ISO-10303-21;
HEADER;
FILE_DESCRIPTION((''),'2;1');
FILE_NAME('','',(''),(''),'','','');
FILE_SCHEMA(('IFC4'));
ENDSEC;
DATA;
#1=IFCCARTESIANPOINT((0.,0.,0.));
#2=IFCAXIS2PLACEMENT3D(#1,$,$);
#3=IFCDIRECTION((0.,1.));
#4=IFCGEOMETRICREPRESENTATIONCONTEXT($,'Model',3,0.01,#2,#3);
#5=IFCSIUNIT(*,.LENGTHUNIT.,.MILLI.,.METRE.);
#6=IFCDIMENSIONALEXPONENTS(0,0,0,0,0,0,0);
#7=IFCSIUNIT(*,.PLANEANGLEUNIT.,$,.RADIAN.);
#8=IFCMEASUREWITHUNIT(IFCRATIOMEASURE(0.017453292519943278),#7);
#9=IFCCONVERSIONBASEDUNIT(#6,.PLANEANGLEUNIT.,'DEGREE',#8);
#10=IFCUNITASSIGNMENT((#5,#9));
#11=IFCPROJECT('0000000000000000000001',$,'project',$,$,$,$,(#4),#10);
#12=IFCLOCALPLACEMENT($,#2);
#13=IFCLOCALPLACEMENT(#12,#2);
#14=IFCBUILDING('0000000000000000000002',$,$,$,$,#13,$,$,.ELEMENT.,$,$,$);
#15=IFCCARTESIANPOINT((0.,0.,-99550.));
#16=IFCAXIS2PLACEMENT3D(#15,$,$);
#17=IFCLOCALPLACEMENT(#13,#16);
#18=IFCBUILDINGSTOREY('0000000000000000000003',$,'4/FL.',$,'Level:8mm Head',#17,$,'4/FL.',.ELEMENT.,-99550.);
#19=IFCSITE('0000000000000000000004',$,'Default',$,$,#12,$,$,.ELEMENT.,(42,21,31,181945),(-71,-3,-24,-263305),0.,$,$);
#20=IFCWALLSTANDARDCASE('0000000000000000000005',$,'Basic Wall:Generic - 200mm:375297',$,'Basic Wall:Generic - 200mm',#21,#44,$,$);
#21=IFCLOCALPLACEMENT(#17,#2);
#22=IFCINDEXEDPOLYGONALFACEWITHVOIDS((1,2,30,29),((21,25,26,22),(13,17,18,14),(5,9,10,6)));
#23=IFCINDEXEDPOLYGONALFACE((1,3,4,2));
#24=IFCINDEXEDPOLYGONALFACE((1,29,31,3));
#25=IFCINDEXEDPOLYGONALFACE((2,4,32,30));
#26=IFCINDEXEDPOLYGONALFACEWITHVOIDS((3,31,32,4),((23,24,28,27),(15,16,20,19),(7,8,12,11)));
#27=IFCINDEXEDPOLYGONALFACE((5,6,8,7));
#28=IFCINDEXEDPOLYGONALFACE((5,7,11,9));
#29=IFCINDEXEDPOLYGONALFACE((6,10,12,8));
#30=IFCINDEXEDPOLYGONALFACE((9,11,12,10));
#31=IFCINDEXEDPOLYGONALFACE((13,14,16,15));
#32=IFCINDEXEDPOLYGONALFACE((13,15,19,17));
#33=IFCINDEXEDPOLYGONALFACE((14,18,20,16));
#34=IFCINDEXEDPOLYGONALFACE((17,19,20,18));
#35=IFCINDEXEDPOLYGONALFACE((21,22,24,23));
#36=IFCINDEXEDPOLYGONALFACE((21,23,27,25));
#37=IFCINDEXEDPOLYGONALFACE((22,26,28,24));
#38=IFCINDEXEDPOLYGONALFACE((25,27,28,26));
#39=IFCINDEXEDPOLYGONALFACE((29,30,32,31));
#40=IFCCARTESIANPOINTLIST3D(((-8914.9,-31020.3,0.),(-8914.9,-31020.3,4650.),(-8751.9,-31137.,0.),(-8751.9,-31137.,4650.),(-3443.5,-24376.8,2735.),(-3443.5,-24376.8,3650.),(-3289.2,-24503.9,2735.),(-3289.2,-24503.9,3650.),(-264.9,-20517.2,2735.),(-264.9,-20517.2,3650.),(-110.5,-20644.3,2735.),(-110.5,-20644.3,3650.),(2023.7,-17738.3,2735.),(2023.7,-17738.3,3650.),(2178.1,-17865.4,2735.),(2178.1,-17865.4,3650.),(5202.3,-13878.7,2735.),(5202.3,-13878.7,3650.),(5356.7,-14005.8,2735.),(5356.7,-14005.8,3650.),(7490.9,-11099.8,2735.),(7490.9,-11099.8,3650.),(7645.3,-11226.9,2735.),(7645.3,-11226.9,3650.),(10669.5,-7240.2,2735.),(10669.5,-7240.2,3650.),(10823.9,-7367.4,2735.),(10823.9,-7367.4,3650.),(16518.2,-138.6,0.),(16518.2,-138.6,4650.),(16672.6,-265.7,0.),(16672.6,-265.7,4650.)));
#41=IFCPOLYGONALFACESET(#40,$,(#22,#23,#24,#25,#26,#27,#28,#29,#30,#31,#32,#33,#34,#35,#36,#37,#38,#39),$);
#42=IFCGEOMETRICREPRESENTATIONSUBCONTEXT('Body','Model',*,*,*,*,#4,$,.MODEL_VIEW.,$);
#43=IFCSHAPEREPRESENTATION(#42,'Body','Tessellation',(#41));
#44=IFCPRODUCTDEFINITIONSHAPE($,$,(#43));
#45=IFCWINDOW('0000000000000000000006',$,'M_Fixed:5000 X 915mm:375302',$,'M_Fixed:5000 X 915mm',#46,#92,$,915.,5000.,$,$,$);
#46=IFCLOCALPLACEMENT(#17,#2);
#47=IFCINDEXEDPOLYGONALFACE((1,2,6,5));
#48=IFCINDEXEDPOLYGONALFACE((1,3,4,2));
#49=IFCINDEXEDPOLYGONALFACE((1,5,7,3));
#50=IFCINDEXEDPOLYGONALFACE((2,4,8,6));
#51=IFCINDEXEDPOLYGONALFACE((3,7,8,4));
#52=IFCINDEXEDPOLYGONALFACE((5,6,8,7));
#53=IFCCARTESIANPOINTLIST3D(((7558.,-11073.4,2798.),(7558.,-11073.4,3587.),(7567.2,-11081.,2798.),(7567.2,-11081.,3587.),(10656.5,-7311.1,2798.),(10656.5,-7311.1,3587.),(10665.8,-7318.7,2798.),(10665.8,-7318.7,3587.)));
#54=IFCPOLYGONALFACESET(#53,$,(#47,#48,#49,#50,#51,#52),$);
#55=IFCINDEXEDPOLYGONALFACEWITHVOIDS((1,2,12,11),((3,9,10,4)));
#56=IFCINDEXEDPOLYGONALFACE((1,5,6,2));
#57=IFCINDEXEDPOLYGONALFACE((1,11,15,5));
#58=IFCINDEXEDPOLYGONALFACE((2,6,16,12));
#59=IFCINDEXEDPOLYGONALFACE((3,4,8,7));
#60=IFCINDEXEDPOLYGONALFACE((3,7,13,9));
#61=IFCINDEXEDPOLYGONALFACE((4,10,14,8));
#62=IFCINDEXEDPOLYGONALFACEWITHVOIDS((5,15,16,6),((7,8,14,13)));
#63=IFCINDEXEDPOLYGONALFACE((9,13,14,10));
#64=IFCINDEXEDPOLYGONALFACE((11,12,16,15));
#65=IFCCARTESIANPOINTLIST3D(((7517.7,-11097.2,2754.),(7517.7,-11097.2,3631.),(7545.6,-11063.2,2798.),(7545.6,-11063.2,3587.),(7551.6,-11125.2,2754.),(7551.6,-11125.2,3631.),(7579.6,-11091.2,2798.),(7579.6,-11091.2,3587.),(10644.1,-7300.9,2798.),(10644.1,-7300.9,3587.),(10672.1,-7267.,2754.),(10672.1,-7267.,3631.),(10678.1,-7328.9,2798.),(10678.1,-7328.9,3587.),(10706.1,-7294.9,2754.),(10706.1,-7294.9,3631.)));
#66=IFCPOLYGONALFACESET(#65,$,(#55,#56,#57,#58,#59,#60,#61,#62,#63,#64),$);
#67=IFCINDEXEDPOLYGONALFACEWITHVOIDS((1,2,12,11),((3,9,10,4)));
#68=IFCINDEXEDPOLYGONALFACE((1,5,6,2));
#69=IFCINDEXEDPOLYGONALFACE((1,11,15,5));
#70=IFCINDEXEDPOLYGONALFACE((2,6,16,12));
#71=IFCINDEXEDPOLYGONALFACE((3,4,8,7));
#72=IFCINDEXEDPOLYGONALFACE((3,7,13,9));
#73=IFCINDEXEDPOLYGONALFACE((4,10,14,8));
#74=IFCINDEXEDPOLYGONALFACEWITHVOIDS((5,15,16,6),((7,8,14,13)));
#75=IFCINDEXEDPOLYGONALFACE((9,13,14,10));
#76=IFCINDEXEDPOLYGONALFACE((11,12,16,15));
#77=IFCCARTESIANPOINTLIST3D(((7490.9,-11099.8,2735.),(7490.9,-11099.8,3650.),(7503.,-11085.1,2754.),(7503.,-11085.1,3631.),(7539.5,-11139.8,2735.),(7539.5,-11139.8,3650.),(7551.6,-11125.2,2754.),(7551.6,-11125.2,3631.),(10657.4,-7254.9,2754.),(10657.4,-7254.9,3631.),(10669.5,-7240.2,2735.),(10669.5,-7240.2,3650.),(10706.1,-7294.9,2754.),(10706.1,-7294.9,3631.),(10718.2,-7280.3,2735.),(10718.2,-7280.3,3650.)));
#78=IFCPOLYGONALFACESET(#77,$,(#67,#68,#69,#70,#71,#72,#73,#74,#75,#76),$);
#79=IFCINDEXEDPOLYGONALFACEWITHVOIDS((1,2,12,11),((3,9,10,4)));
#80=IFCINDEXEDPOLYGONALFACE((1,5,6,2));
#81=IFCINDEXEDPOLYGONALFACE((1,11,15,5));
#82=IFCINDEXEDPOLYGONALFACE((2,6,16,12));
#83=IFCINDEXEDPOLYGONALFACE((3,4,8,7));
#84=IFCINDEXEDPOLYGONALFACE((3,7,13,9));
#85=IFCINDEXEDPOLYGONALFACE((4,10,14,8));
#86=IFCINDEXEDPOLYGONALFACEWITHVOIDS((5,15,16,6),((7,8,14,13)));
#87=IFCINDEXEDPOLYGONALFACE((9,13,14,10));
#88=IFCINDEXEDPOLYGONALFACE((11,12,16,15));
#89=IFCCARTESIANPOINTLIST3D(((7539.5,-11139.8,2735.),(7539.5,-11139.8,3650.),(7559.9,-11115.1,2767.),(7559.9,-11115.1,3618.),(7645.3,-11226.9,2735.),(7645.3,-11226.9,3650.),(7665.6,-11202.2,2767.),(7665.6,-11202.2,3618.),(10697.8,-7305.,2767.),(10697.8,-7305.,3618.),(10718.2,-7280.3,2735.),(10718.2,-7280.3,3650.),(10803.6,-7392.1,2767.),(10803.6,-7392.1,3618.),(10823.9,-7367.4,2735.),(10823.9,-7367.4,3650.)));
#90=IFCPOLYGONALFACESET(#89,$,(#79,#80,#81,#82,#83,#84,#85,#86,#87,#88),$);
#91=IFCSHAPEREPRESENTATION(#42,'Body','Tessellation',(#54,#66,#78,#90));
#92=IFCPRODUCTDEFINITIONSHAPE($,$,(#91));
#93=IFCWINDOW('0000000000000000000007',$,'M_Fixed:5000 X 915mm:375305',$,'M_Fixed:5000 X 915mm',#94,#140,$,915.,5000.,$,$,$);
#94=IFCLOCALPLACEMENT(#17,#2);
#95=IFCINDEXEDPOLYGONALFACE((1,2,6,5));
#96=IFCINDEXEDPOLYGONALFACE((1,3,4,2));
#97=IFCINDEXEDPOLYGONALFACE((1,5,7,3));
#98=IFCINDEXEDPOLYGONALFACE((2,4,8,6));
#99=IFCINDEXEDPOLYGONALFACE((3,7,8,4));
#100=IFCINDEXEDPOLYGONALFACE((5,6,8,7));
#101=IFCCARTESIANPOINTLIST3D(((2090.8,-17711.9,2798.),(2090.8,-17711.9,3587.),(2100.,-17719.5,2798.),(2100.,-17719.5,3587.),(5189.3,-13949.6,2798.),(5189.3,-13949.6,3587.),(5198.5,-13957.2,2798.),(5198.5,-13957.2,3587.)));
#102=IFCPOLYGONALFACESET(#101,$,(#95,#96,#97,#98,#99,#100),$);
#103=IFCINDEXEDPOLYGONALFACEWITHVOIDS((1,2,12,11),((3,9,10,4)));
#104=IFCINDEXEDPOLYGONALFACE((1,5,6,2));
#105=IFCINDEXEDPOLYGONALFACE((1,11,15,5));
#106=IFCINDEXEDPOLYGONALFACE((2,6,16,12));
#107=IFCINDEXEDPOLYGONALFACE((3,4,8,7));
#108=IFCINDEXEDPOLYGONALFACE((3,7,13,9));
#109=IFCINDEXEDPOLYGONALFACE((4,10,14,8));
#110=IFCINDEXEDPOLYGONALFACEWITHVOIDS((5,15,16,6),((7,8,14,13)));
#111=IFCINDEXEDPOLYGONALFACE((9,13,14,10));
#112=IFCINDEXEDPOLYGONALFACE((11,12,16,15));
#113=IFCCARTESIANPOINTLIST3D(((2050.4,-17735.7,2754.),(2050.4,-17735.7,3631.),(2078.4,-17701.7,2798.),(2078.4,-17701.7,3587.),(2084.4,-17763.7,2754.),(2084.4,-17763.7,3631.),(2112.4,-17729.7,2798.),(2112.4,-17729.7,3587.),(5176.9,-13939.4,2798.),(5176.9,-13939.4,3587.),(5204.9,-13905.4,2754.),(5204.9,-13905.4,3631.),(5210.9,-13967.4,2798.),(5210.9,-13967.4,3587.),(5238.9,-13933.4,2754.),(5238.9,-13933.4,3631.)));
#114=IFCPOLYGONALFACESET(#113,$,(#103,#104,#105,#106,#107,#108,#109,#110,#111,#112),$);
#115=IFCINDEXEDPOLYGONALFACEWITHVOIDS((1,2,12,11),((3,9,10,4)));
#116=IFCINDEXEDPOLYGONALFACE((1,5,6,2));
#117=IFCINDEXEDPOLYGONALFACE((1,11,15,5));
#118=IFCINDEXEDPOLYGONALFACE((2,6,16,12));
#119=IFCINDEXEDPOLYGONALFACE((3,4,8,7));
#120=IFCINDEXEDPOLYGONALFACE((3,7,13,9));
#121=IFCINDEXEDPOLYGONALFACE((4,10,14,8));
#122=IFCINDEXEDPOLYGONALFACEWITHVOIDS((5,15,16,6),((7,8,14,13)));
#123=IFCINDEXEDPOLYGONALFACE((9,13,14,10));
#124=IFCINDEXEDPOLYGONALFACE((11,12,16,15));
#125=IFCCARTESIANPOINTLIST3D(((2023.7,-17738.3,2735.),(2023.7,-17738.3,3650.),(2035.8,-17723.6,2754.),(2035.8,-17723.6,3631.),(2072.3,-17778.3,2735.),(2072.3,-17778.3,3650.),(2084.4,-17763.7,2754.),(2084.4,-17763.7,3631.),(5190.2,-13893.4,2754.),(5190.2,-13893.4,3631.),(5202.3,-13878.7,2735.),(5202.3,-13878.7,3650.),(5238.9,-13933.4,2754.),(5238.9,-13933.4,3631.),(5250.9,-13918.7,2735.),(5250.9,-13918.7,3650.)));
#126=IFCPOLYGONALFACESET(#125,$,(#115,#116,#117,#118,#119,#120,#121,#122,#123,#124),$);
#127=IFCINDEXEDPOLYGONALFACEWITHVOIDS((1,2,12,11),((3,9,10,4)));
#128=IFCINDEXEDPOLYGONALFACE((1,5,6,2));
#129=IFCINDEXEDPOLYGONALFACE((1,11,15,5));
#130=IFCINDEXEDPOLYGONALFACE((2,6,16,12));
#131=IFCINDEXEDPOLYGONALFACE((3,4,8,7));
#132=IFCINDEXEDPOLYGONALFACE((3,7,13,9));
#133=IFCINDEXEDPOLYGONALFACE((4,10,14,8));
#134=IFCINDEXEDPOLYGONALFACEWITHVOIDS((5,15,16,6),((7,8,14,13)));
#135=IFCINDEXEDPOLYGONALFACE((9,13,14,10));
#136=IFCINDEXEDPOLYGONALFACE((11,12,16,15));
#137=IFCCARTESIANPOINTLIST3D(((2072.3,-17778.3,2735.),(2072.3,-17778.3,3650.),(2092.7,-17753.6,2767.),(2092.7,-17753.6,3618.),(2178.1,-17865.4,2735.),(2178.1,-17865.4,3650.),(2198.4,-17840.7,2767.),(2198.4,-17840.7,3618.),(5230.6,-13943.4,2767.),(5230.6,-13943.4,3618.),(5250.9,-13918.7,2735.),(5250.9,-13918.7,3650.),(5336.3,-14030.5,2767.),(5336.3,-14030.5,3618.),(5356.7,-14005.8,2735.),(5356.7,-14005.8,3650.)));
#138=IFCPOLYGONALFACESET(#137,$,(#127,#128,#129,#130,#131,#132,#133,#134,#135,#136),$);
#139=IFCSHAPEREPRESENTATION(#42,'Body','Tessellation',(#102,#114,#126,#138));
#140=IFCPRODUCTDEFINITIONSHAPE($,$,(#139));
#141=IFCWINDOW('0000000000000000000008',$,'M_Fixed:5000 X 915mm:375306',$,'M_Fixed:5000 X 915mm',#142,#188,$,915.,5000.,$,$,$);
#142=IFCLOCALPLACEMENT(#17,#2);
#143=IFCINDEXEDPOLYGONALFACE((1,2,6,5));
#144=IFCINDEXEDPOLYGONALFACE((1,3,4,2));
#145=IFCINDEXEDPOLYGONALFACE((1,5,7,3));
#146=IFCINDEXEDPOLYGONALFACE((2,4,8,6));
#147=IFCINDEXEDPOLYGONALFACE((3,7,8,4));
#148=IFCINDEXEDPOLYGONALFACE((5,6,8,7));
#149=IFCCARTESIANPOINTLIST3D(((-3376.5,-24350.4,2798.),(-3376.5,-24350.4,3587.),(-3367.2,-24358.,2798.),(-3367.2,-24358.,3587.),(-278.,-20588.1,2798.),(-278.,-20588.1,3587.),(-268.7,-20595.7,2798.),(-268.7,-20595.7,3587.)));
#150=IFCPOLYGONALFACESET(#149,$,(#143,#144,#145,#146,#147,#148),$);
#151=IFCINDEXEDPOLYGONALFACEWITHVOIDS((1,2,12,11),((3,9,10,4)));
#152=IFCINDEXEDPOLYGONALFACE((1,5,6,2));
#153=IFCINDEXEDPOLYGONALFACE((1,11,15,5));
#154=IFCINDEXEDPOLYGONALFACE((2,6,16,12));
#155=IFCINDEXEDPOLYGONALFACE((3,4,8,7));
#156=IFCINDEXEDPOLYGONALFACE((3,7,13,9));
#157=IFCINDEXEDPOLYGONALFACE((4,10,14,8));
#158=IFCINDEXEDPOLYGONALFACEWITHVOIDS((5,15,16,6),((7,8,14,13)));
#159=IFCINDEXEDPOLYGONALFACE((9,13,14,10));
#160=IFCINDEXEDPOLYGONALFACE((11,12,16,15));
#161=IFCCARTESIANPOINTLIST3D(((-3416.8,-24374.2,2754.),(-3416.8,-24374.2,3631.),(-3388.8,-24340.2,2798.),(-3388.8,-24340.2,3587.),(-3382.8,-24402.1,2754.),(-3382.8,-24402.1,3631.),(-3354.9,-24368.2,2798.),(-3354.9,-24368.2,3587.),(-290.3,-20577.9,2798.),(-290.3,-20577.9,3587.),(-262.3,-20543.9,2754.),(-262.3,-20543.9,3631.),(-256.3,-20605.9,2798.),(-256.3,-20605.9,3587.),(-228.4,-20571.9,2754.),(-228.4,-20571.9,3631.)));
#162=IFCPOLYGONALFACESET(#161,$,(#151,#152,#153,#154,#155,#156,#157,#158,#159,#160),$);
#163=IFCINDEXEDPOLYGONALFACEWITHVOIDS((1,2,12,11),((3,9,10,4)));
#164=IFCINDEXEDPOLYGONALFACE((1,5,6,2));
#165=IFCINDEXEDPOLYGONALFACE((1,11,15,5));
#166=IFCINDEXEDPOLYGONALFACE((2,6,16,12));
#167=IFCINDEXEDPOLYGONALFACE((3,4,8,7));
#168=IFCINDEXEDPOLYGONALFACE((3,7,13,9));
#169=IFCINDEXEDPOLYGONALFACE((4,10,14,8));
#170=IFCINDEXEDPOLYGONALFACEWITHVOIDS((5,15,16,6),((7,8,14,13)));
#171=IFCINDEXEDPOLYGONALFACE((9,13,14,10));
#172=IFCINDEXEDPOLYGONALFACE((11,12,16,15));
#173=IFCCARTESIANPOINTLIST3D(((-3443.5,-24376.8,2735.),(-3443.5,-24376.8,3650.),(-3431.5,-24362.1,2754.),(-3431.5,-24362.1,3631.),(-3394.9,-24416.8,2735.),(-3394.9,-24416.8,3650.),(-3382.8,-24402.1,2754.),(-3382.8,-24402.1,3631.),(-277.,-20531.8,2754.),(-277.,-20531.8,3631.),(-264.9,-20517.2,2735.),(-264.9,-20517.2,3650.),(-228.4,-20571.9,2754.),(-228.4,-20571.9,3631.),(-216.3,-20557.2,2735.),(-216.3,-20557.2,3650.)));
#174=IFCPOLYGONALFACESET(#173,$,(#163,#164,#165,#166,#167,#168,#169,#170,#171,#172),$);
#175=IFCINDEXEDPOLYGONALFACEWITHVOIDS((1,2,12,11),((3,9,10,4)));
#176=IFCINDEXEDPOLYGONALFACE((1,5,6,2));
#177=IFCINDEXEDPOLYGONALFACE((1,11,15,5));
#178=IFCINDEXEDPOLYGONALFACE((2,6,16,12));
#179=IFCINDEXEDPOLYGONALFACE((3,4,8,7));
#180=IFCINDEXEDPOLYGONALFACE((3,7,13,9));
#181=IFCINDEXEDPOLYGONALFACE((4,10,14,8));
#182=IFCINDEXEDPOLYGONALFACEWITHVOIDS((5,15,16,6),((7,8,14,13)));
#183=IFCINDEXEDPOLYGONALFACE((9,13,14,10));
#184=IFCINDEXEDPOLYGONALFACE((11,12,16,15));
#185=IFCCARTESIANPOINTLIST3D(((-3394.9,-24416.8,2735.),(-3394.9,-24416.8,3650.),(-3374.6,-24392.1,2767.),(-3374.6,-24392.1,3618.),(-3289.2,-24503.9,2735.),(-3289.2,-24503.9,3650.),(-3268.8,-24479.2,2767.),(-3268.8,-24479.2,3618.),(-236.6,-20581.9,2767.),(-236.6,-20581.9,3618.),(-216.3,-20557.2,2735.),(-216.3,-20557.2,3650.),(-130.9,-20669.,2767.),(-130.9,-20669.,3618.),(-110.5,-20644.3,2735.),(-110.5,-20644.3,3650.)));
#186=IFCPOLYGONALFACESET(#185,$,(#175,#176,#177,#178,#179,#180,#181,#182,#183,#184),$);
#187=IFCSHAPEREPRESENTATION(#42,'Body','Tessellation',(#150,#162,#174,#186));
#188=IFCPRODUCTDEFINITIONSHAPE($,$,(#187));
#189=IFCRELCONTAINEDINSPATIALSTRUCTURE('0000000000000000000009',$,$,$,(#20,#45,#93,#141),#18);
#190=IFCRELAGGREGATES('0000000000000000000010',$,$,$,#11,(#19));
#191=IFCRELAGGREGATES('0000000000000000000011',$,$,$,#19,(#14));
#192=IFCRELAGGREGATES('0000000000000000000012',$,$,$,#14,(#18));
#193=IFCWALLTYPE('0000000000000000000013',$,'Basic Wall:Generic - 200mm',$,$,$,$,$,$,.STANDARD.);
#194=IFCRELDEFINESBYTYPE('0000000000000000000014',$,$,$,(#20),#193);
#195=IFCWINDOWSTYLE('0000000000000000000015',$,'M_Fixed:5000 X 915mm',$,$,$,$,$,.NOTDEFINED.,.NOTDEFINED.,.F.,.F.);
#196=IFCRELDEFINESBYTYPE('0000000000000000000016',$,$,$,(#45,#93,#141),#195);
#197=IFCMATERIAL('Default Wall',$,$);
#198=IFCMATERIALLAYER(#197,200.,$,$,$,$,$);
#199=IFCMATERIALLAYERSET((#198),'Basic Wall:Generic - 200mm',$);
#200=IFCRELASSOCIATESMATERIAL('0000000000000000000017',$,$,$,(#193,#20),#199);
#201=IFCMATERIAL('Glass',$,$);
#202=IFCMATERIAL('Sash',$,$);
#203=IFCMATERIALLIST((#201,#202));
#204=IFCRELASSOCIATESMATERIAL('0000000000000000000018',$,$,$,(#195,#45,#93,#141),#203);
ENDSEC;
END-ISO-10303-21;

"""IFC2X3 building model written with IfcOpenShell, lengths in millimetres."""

from ifc_helpers import new_model, entity, si_unit, converted_unit, direction, frame, frame_2d, origin, place, context, subcontext, project, spatial, polyline, rectangle, outline, extrude, source, transform, mapped, material, material_list, layer, layer_set, layer_usage, type_object, type_shapes, element, fill, save


model = new_model("IFC2X3")

# Units and contexts
model_context = context("Model", 3, precision=0.01, world=origin(), true_north=direction((0.0, 1.0)))
body_context = subcontext(model_context, "Body", "Model", "MODEL_VIEW")
ifc_project = project(units=[si_unit("LENGTHUNIT", "METRE", prefix="MILLI"), converted_unit("PLANEANGLEUNIT", "DEGREE", entity("IfcRatioMeasure", 0.017453292519943278), si_unit("PLANEANGLEUNIT", "RADIAN"), dimensions=[0, 0, 0, 0, 0, 0, 0])], contexts=[model_context])

# Site, building, storey
site_placement = place(None, origin())
site = spatial("IfcSite", under=ifc_project, at=site_placement, Name="Default", CompositionType="ELEMENT", RefLatitude=(42, 21, 31, 181945), RefLongitude=(-71, -3, -24, -263305), RefElevation=0.0)
building_placement = place(site_placement, origin())
building = spatial("IfcBuilding", under=site, at=building_placement, CompositionType="ELEMENT")
storey_placement = place(building_placement, frame((0.0, 0.0, -99550.0)))
storey = spatial("IfcBuildingStorey", under=building, at=storey_placement, Name="4/FL.", ObjectType="Level:8mm Head", LongName="4/FL.", CompositionType="ELEMENT", Elevation=-99550.0)

# Shared definitions
ifc_material_1 = material(Name="Default Wall")
ifc_layer = layer(ifc_material_1, 200.0)
ifc_layer_set = layer_set([ifc_layer], Name="Basic Wall:Generic - 200mm")
ifc_layer_usage = layer_usage(ifc_layer_set, "AXIS2", "NEGATIVE", 100.0)
wall_type = type_object("IfcWallType", Name="Basic Wall:Generic - 200mm", PredefinedType="STANDARD", material=ifc_layer_set)

# Wall, openings, windows
wall_1_placement = place(storey_placement, frame((17103.9, 415.4, 0.0), z_axis=(0.0, 0.0, 1.0), x_axis=(-0.635723, -0.771917, 0.0)))
wall_1 = element("IfcWallStandardCase", 1, at=wall_1_placement, inside=storey, type_object=wall_type, material=ifc_layer_usage, Name="Basic Wall:Generic - 200mm:375297", ObjectType="Basic Wall:Generic - 200mm", context=body_context, shape_type="SweptSolid", body=[
    extrude(outline(polyline([(40806.5, -100.0), (40793.0, 100.0), (37219.3, 100.0), (37019.3, 100.0), (800.0, 100.0), (800.0, -100.0), (37019.3, -100.0), (37219.3, -100.0), (40806.5, -100.0)])), origin(), (0.0, 0.0, 1.0), 4650.0),
])
opening_1_placement = place(wall_1_placement, origin())
element("IfcOpeningElement", 2, at=opening_1_placement, cuts=wall_1, ObjectType="Opening", context=body_context, shape_type="SweptSolid", body=[
    extrude(rectangle(XDim=1000.0, YDim=1012.7, at=frame_2d((0.0, 0.0), x_axis=(1.0, 0.0))), frame((293.7, -183.3, 500.0), z_axis=(0.0, 1.0, 0.0), x_axis=(0.0, 0.0, -1.0)), (0.0, 0.0, 1.0), 1010.1),
])
opening_2_placement = place(wall_1_placement, frame((15000.0, 100.0, 2735.0)))
opening_2 = element("IfcOpeningElement", 3, at=opening_2_placement, cuts=wall_1, ObjectType="Opening", context=body_context, shape_type="SweptSolid", body=[
    extrude(rectangle(XDim=915.0, YDim=5000.0, at=frame_2d((457.5, 2500.0), x_axis=(1.0, 0.0))), frame((0.0, 0.0, 0.0), z_axis=(0.0, -1.0, 0.0), x_axis=(0.0, 0.0, 1.0)), (0.0, 0.0, 1.0), 200.0),
])
opening_3_placement = place(wall_1_placement, frame((23600.0, 100.0, 2735.0)))
opening_3 = element("IfcOpeningElement", 4, at=opening_3_placement, cuts=wall_1, ObjectType="Opening", context=body_context, shape_type="SweptSolid", body=[
    extrude(rectangle(XDim=915.0, YDim=5000.0, at=frame_2d((457.5, 2500.0), x_axis=(1.0, 0.0))), frame((0.0, 0.0, 0.0), z_axis=(0.0, -1.0, 0.0), x_axis=(0.0, 0.0, 1.0)), (0.0, 0.0, 1.0), 200.0),
])
opening_4_placement = place(wall_1_placement, frame((32200.0, 100.0, 2735.0)))
opening_4 = element("IfcOpeningElement", 5, at=opening_4_placement, cuts=wall_1, ObjectType="Opening", context=body_context, shape_type="SweptSolid", body=[
    extrude(rectangle(XDim=915.0, YDim=5000.0, at=frame_2d((457.5, 2500.0), x_axis=(1.0, 0.0))), frame((0.0, 0.0, 0.0), z_axis=(0.0, -1.0, 0.0), x_axis=(0.0, 0.0, 1.0)), (0.0, 0.0, 1.0), 200.0),
])
ifc_material_2 = material(Name="Glass")
ifc_material_3 = material(Name="Sash")
ifc_material_list = material_list([ifc_material_2, ifc_material_3])
window_style_1 = type_object("IfcWindowStyle", Name="M_Fixed:5000 X 915mm", ConstructionType="NOTDEFINED", OperationType="NOTDEFINED", ParameterTakesPrecedence=False, Sizeable=False, material=ifc_material_list)
shared_shape_1 = source(origin(), body_context, "Body", "SweptSolid", [
    extrude(rectangle(XDim=12.0, YDim=4874.0, at=frame_2d((0.0, 0.0), x_axis=(1.0, 0.0))), frame((2500.0, 159.0, 63.0), z_axis=(0.0, 0.0, 1.0), x_axis=(0.0, -1.0, 0.0)), (0.0, 0.0, 1.0), 789.0),
    extrude(outline(polyline([(-2481.0, -438.5), (2481.0, -438.5), (2481.0, 438.5), (-2481.0, 438.5), (-2481.0, -438.5)]), holes=[polyline([(-2437.0, -394.5), (-2437.0, 394.5), (2437.0, 394.5), (2437.0, -394.5), (-2437.0, -394.5)])]), frame((2500.0, 137.0, 457.5), z_axis=(0.0, 1.0, 0.0), x_axis=(1.0, 0.0, 0.0)), (0.0, 0.0, 1.0), 44.0),
    extrude(outline(polyline([(-2500.0, -457.5), (2500.0, -457.5), (2500.0, 457.5), (-2500.0, 457.5), (-2500.0, -457.5)]), holes=[polyline([(-2481.0, -438.5), (-2481.0, 438.5), (2481.0, 438.5), (2481.0, -438.5), (-2481.0, -438.5)])]), frame((2500.0, 137.0, 457.5), z_axis=(0.0, 1.0, 0.0), x_axis=(1.0, 0.0, 0.0)), (0.0, 0.0, 1.0), 63.0),
    extrude(outline(polyline([(-2500.0, -457.5), (2500.0, -457.5), (2500.0, 457.5), (-2500.0, 457.5), (-2500.0, -457.5)]), holes=[polyline([(-2468.0, -425.5), (-2468.0, 425.5), (2468.0, 425.5), (2468.0, -425.5), (-2468.0, -425.5)])]), frame((2500.0, 0.0, 457.5), z_axis=(0.0, 1.0, 0.0), x_axis=(1.0, 0.0, 0.0)), (0.0, 0.0, 1.0), 137.0),
])
type_shapes(window_style_1, [shared_shape_1])
window_1_placement = place(opening_2_placement, frame((0.0, 0.0, 0.0), z_axis=(0.0, 0.0, 1.0), x_axis=(-1.0, 0.0, 0.0)))
window_1 = element("IfcWindow", 6, at=window_1_placement, inside=storey, type_object=window_style_1, material=ifc_material_list, Name="M_Fixed:5000 X 915mm:375302", ObjectType="M_Fixed:5000 X 915mm", OverallHeight=915.0, OverallWidth=5000.0, context=body_context, shape_type="MappedRepresentation", body=[
    mapped(shared_shape_1, transform((0.0, 0.0, 0.0), scale=1.0)),
])
fill(opening_2, window_1)
window_2_placement = place(opening_3_placement, frame((0.0, 0.0, 0.0), z_axis=(0.0, 0.0, 1.0), x_axis=(-1.0, 0.0, 0.0)))
window_2 = element("IfcWindow", 7, at=window_2_placement, inside=storey, type_object=window_style_1, material=ifc_material_list, Name="M_Fixed:5000 X 915mm:375305", ObjectType="M_Fixed:5000 X 915mm", OverallHeight=915.0, OverallWidth=5000.0, context=body_context, shape_type="MappedRepresentation", body=[
    mapped(shared_shape_1, transform((0.0, 0.0, 0.0), scale=1.0)),
])
fill(opening_3, window_2)
window_3_placement = place(opening_4_placement, frame((0.0, 0.0, 0.0), z_axis=(0.0, 0.0, 1.0), x_axis=(-1.0, 0.0, 0.0)))
window_3 = element("IfcWindow", 8, at=window_3_placement, inside=storey, type_object=window_style_1, material=ifc_material_list, Name="M_Fixed:5000 X 915mm:375306", ObjectType="M_Fixed:5000 X 915mm", OverallHeight=915.0, OverallWidth=5000.0, context=body_context, shape_type="MappedRepresentation", body=[
    mapped(shared_shape_1, transform((0.0, 0.0, 0.0), scale=1.0)),
])
fill(opening_4, window_3)

save(model, "model.ifc")
